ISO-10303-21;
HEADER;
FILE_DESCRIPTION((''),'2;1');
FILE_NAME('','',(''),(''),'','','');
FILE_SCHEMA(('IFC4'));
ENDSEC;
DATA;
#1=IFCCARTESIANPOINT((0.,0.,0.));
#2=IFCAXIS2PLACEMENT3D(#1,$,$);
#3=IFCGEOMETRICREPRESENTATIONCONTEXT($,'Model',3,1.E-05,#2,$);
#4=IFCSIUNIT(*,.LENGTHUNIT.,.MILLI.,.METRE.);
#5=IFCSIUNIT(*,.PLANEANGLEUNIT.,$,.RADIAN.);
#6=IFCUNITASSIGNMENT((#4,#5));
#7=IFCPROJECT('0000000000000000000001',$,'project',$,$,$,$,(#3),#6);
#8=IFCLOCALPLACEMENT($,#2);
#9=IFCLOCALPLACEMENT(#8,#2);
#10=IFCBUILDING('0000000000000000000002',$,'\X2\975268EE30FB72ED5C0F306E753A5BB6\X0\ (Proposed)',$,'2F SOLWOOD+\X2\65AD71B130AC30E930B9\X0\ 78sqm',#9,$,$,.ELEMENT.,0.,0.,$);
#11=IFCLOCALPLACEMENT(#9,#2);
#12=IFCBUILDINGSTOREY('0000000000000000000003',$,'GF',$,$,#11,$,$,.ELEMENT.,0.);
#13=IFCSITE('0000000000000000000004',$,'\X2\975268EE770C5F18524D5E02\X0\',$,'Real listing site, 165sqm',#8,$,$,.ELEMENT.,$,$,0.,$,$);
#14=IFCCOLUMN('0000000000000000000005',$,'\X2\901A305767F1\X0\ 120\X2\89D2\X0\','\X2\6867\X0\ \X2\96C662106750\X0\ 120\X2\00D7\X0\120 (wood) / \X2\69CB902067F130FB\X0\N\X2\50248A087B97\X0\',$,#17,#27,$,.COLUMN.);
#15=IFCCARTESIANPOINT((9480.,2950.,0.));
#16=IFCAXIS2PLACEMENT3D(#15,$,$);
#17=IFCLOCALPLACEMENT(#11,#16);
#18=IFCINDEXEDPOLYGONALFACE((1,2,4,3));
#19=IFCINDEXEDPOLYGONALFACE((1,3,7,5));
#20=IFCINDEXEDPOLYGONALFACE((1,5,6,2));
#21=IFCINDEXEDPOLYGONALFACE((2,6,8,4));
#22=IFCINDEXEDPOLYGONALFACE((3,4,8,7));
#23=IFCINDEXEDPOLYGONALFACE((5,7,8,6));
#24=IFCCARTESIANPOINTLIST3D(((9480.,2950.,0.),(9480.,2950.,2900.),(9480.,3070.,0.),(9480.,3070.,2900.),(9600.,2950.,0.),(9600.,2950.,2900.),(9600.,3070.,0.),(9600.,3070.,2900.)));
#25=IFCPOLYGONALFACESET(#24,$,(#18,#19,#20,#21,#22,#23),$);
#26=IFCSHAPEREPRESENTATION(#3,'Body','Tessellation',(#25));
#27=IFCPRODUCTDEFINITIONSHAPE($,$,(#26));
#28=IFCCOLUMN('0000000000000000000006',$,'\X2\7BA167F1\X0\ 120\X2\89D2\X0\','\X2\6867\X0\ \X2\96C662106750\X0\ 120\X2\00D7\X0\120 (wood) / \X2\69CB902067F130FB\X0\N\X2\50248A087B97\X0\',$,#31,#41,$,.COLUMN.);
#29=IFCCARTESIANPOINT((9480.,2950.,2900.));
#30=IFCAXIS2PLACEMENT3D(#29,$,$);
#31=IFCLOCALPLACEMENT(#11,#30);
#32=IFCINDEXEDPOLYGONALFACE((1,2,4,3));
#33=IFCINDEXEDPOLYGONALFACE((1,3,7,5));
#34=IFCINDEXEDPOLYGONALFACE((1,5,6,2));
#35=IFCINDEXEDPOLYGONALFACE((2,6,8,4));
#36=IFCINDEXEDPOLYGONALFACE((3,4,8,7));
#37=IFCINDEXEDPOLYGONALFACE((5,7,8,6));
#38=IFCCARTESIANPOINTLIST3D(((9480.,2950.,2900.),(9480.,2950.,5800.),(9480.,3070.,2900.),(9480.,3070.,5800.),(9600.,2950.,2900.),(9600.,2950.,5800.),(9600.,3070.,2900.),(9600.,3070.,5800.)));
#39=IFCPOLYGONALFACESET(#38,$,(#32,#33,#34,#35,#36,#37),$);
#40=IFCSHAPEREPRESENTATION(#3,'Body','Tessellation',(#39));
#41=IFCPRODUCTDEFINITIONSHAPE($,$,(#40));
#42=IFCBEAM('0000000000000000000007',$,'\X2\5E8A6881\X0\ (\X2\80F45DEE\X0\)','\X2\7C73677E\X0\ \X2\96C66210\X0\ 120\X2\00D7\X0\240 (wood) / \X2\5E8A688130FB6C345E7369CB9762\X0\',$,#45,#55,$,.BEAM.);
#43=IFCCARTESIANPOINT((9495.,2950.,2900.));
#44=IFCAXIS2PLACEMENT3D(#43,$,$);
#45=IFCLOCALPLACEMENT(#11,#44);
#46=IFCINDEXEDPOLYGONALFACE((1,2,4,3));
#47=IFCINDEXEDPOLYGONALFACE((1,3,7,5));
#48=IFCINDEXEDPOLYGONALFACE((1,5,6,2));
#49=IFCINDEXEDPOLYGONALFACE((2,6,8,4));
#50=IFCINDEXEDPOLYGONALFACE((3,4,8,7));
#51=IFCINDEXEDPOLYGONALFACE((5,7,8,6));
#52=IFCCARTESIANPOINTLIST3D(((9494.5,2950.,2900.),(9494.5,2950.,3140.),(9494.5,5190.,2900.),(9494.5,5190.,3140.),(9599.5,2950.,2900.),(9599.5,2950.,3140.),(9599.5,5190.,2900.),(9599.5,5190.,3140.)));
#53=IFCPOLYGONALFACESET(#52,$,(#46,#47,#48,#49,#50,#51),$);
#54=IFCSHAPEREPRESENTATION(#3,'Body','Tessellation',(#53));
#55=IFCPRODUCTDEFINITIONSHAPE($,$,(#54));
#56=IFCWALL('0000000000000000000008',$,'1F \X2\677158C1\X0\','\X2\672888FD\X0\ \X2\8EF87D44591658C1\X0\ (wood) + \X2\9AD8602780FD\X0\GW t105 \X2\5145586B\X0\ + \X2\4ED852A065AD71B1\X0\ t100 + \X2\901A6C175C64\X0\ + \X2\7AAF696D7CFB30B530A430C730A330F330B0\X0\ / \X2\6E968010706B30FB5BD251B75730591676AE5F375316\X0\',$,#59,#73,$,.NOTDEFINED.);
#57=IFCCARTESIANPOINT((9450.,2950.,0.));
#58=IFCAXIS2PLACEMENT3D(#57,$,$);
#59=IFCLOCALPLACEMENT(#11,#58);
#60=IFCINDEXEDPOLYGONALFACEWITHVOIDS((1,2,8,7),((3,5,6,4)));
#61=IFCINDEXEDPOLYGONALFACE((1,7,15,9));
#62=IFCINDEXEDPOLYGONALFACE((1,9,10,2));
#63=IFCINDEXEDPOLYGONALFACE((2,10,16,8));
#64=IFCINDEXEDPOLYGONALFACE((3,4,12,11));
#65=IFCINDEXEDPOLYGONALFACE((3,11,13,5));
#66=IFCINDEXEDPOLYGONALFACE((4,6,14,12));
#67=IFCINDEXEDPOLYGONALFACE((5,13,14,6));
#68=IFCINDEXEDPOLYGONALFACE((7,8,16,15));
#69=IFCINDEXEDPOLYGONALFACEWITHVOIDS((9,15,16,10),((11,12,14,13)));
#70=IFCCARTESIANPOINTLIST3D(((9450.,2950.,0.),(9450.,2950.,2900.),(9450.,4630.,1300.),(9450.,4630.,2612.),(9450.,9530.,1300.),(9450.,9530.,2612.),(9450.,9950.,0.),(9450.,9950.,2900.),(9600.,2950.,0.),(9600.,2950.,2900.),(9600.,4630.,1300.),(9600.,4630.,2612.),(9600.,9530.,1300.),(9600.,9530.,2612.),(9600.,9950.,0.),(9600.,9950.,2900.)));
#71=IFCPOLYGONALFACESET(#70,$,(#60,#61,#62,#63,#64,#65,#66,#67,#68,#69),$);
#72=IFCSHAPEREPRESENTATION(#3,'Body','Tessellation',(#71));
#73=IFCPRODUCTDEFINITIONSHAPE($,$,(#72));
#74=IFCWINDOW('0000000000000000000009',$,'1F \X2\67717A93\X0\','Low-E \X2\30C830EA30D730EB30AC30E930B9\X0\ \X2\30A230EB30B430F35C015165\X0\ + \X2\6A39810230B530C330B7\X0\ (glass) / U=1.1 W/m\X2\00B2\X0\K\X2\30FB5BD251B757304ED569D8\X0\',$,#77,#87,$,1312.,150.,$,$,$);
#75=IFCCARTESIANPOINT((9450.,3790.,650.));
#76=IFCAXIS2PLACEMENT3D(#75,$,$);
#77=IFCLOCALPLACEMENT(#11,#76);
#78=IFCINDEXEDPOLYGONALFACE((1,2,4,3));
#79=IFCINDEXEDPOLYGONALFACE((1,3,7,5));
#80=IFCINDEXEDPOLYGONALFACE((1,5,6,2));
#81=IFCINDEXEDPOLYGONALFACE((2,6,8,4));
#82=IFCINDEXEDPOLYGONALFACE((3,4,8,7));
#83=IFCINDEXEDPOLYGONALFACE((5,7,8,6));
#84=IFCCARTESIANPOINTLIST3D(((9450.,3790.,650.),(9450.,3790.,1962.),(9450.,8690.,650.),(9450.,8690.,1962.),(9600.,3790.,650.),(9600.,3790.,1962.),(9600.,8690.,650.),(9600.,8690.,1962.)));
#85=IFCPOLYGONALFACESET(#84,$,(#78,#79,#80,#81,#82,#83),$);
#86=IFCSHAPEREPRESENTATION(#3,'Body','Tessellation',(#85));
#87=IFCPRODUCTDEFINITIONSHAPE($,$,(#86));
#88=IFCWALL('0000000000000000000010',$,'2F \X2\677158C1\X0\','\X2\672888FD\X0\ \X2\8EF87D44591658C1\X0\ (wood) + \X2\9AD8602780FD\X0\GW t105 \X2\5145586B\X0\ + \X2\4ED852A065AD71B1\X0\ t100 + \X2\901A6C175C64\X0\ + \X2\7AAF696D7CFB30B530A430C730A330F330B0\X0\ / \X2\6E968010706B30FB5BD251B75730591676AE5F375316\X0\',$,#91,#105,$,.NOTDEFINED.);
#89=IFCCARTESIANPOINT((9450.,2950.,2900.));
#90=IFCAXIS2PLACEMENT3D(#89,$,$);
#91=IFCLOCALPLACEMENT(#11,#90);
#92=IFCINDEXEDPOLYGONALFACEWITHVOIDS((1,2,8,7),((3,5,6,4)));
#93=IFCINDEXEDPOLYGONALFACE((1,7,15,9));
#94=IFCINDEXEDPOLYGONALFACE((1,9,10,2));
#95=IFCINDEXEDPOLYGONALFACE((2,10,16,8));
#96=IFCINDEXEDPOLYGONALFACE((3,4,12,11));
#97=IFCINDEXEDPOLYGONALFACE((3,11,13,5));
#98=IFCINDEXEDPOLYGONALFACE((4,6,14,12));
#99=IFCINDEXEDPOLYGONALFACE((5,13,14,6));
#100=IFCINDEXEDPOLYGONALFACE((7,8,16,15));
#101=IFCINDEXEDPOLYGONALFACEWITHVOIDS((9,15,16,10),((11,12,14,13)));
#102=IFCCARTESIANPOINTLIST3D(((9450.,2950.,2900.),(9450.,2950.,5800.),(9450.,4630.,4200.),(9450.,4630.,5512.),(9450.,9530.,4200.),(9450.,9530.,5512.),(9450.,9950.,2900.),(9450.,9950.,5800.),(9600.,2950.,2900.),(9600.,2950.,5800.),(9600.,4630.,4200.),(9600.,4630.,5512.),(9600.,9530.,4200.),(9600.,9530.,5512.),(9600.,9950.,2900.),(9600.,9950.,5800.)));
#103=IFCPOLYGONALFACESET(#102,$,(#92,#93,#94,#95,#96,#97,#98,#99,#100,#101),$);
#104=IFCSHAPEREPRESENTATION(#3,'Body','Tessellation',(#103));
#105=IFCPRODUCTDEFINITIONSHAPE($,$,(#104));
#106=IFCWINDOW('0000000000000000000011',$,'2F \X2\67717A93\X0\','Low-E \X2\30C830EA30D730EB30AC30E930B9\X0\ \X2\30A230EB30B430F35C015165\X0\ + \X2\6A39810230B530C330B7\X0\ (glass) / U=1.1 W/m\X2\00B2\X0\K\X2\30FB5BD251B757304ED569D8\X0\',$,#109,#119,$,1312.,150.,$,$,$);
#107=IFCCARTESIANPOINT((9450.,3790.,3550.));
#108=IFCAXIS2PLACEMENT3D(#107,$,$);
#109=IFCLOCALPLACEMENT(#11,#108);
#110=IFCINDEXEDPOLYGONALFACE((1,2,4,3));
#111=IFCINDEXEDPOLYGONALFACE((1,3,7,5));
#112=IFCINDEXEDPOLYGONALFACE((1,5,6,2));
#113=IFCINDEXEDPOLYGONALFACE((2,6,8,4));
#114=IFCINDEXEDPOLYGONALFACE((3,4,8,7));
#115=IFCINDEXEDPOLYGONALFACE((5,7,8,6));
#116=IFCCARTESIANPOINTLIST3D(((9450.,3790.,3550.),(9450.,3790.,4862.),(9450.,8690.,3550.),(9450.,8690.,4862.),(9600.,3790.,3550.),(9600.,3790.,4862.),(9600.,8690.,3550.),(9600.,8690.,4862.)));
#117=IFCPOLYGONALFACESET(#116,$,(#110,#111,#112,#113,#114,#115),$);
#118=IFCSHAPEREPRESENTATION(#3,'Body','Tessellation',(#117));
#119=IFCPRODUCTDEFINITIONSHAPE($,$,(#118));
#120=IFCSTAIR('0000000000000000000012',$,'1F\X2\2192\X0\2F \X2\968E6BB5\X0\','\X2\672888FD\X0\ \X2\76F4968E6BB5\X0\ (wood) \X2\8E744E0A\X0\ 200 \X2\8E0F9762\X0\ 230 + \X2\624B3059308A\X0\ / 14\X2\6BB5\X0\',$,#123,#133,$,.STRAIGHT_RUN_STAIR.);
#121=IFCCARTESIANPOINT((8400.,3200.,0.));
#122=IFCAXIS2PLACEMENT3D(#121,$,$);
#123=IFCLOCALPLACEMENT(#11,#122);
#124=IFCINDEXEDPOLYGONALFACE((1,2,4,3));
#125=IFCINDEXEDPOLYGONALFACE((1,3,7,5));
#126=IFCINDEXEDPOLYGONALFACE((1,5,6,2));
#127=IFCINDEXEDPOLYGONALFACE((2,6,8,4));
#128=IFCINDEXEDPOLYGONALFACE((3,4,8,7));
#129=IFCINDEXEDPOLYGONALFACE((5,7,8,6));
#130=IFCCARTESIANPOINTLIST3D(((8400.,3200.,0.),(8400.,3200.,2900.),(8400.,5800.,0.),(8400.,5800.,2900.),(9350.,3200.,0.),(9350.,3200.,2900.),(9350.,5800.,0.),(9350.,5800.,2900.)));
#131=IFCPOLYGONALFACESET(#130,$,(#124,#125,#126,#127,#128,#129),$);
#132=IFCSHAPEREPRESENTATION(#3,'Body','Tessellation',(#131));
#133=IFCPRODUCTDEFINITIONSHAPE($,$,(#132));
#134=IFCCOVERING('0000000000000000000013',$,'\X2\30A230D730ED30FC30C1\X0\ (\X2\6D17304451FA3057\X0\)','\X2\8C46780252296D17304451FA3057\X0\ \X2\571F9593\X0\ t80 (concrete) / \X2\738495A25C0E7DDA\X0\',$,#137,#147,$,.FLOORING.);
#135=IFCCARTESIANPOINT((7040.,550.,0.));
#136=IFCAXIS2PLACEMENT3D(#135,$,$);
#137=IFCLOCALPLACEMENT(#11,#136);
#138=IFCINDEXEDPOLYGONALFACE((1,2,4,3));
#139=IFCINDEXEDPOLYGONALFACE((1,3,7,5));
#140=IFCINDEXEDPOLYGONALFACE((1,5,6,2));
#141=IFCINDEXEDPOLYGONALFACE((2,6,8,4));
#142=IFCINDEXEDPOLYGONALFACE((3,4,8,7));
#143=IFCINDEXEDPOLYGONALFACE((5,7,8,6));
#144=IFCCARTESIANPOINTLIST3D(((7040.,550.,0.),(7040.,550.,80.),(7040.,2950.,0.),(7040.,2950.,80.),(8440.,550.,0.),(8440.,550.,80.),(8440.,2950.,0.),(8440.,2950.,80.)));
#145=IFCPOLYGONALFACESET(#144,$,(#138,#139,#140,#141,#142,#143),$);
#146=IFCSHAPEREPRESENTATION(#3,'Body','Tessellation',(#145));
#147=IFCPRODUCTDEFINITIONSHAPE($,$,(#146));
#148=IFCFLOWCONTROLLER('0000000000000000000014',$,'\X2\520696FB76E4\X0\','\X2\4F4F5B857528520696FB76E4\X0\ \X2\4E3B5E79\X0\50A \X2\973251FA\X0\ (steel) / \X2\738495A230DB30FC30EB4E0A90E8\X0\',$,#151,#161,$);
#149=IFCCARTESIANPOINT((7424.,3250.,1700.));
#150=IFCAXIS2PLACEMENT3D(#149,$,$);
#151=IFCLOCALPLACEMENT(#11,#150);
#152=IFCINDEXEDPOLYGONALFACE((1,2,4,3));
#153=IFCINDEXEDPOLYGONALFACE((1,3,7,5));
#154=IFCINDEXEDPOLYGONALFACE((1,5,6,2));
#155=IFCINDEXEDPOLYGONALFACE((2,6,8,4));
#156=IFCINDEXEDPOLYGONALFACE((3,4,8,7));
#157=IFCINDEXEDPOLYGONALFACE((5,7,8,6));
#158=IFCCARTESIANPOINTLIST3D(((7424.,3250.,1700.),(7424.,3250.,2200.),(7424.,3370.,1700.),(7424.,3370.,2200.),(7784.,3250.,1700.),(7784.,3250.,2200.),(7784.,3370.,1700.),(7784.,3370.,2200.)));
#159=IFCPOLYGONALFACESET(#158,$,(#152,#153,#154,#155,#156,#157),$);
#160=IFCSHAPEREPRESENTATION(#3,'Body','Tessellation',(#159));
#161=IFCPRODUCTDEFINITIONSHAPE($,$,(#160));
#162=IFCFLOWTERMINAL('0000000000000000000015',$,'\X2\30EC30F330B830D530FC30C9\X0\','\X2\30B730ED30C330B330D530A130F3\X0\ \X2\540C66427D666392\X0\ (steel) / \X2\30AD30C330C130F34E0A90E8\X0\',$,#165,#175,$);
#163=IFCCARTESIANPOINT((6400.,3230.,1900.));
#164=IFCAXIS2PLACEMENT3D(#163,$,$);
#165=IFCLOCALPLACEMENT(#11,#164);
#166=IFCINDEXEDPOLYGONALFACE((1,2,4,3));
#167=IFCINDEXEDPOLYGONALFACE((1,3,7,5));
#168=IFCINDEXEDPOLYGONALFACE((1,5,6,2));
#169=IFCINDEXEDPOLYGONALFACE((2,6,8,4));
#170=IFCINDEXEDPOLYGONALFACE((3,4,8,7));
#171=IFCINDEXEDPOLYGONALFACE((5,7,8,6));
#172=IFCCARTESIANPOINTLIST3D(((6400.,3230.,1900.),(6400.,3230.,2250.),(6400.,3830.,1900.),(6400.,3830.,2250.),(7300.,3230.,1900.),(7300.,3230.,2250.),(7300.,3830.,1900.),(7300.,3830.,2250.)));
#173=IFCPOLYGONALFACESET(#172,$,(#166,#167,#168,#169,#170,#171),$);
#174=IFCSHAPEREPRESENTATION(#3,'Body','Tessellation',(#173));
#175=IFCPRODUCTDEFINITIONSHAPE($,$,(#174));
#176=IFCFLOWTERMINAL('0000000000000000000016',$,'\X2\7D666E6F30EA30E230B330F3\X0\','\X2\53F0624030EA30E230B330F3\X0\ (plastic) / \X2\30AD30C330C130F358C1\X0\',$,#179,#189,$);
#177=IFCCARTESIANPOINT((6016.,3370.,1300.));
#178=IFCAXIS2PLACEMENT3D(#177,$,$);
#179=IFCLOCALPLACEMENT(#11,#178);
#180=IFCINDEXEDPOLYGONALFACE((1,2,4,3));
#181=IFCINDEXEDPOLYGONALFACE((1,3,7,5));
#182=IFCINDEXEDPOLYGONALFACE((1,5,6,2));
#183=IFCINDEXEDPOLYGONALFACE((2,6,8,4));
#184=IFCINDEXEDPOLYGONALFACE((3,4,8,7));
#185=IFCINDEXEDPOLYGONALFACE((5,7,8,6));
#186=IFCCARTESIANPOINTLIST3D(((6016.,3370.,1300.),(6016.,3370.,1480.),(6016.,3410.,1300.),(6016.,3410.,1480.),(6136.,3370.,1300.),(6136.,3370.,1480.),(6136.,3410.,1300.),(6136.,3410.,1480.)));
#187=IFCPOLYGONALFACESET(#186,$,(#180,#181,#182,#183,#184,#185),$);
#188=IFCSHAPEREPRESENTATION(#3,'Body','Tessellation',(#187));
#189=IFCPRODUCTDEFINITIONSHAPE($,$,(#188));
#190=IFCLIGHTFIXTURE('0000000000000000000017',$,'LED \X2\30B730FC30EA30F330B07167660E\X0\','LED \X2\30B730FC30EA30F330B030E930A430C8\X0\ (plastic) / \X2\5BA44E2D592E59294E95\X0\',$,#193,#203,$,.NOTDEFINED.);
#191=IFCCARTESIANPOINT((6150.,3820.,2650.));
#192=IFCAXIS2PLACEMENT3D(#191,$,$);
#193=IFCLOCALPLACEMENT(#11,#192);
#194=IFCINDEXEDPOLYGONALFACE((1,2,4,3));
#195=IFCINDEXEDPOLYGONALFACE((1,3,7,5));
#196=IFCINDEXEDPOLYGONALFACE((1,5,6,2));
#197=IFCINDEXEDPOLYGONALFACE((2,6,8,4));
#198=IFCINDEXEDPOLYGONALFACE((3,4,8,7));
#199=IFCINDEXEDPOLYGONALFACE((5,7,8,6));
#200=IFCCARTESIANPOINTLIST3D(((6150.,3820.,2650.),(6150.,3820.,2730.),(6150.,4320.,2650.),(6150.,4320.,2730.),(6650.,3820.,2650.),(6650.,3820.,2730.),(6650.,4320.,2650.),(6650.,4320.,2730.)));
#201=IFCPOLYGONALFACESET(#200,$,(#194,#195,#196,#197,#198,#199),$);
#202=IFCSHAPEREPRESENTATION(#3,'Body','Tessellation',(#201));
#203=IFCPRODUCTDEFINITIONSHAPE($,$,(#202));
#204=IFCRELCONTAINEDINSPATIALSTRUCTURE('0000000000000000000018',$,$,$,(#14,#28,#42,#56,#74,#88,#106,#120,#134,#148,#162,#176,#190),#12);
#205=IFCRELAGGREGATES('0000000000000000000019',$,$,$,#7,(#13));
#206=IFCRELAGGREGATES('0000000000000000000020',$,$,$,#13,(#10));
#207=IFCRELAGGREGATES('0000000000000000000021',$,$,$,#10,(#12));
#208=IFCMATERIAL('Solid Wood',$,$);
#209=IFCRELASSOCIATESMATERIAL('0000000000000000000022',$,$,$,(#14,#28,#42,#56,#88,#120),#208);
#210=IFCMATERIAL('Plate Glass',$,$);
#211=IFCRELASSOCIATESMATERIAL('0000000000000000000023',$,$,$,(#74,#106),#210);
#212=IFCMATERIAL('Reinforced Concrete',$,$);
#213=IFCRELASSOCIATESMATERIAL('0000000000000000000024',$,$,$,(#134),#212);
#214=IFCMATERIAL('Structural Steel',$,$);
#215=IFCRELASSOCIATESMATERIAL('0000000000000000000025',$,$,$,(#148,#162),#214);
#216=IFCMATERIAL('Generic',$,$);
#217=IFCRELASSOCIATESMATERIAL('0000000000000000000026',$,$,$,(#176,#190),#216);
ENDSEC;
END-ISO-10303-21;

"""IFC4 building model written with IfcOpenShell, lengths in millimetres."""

from ifc_helpers import new_model, si_unit, frame, frame_2d, origin, place, context, project, spatial, rectangle, extrude, material, element, fill, save


model = new_model("IFC4")

# Units and contexts
model_context = context("Model", 3, precision=1e-05, world=origin())
ifc_project = project(units=[si_unit("LENGTHUNIT", "METRE", prefix="MILLI"), si_unit("PLANEANGLEUNIT", "RADIAN")], contexts=[model_context])

# Site, building, storey
site_placement = place(None, origin())
site = spatial("IfcSite", under=ifc_project, at=site_placement, Name="青森県弘前市", ObjectType="Real listing site, 165sqm", CompositionType="ELEMENT", RefElevation=0.0)
building_placement = place(site_placement, origin())
building = spatial("IfcBuilding", under=site, at=building_placement, Name="青森・狭小の町家 (Proposed)", ObjectType="2F SOLWOOD+断熱ガラス 78sqm", CompositionType="ELEMENT", ElevationOfRefHeight=0.0, ElevationOfTerrain=0.0)
storey_placement = place(building_placement, origin())
storey = spatial("IfcBuildingStorey", under=building, at=storey_placement, Name="GF", CompositionType="ELEMENT", Elevation=0.0)

# Columns
ifc_material_1 = material(Name="Solid Wood")
column_1_placement = place(storey_placement, frame((9480.0, 2950.0, 0.0)))
element("IfcColumn", 1, at=column_1_placement, inside=storey, material=ifc_material_1, Name="通し柱 120角", Description="桧 集成材 120×120 (wood) / 構造柱・N値計算", PredefinedType="COLUMN", context=model_context, shape_type="SweptSolid", body=[
    extrude(rectangle(XDim=120.0, YDim=120.0, at=frame_2d((60.0, 60.0))), frame((9480.0, 2950.0, 0.0)), (0.0, 0.0, 1.0), 2900.0),
])
column_2_placement = place(storey_placement, frame((9480.0, 2950.0, 2900.0)))
element("IfcColumn", 2, at=column_2_placement, inside=storey, material=ifc_material_1, Name="管柱 120角", Description="桧 集成材 120×120 (wood) / 構造柱・N値計算", PredefinedType="COLUMN", context=model_context, shape_type="SweptSolid", body=[
    extrude(rectangle(XDim=120.0, YDim=120.0, at=frame_2d((60.0, 60.0))), frame((9480.0, 2950.0, 2900.0)), (0.0, 0.0, 1.0), 2900.0),
])

# Beam
beam_1_placement = place(storey_placement, frame((9495.0, 2950.0, 2900.0)))
element("IfcBeam", 3, at=beam_1_placement, inside=storey, material=ifc_material_1, Name="床梁 (胴差)", Description="米松 集成 120×240 (wood) / 床梁・水平構面", PredefinedType="BEAM", context=model_context, shape_type="SweptSolid", body=[
    extrude(rectangle(XDim=105.0, YDim=2240.0, at=frame_2d((52.0, 1120.0))), frame((9495.0, 2950.0, 2900.0)), (0.0, 0.0, 1.0), 240.0),
])

# Wall, opening, window
wall_1_placement = place(storey_placement, frame((9450.0, 2950.0, 0.0)))
wall_1 = element("IfcWall", 4, at=wall_1_placement, inside=storey, material=ifc_material_1, Name="1F 東壁", Description="木製 軸組外壁 (wood) + 高性能GW t105 充填 + 付加断熱 t100 + 通気層 + 窯業系サイディング / 準耐火・寒冷地外皮強化", PredefinedType="NOTDEFINED", context=model_context, shape_type="SweptSolid", body=[
    extrude(rectangle(XDim=150.0, YDim=7000.0, at=frame_2d((75.0, 3500.0))), frame((9450.0, 2950.0, 0.0)), (0.0, 0.0, 1.0), 2900.0),
])
opening_1_placement = place(storey_placement, frame((9450.0, 3790.0, 650.0)))
opening_1 = element("IfcOpeningElement", 5, at=opening_1_placement, cuts=wall_1, PredefinedType="NOTDEFINED", context=model_context, shape_type="SweptSolid", body=[
    extrude(rectangle(XDim=150.0, YDim=4900.0, at=frame_2d((75.0, 2450.0))), frame((9450.0, 3790.0, 650.0)), (0.0, 0.0, 1.0), 1312.0),
])
ifc_material_2 = material(Name="Plate Glass")
window_1_placement = place(storey_placement, frame((9450.0, 3790.0, 650.0)))
window_1 = element("IfcWindow", 6, at=window_1_placement, inside=storey, material=ifc_material_2, Name="1F 東窓", Description="Low-E トリプルガラス アルゴン封入 + 樹脂サッシ (glass) / U=1.1 W/m²K・寒冷地仕様", OverallHeight=1312.0, OverallWidth=150.0, context=model_context, shape_type="SweptSolid", body=[
    extrude(rectangle(XDim=150.0, YDim=4900.0, at=frame_2d((75.0, 2450.0))), frame((9450.0, 3790.0, 650.0)), (0.0, 0.0, 1.0), 1312.0),
])
fill(opening_1, window_1)

# Wall, opening, window
wall_2_placement = place(storey_placement, frame((9450.0, 2950.0, 2900.0)))
wall_2 = element("IfcWall", 7, at=wall_2_placement, inside=storey, material=ifc_material_1, Name="2F 東壁", Description="木製 軸組外壁 (wood) + 高性能GW t105 充填 + 付加断熱 t100 + 通気層 + 窯業系サイディング / 準耐火・寒冷地外皮強化", PredefinedType="NOTDEFINED", context=model_context, shape_type="SweptSolid", body=[
    extrude(rectangle(XDim=150.0, YDim=7000.0, at=frame_2d((75.0, 3500.0))), frame((9450.0, 2950.0, 2900.0)), (0.0, 0.0, 1.0), 2900.0),
])
opening_2_placement = place(storey_placement, frame((9450.0, 3790.0, 3550.0)))
opening_2 = element("IfcOpeningElement", 8, at=opening_2_placement, cuts=wall_2, PredefinedType="NOTDEFINED", context=model_context, shape_type="SweptSolid", body=[
    extrude(rectangle(XDim=150.0, YDim=4900.0, at=frame_2d((75.0, 2450.0))), frame((9450.0, 3790.0, 3550.0)), (0.0, 0.0, 1.0), 1312.0),
])
window_2_placement = place(storey_placement, frame((9450.0, 3790.0, 3550.0)))
window_2 = element("IfcWindow", 9, at=window_2_placement, inside=storey, material=ifc_material_2, Name="2F 東窓", Description="Low-E トリプルガラス アルゴン封入 + 樹脂サッシ (glass) / U=1.1 W/m²K・寒冷地仕様", OverallHeight=1312.0, OverallWidth=150.0, context=model_context, shape_type="SweptSolid", body=[
    extrude(rectangle(XDim=150.0, YDim=4900.0, at=frame_2d((75.0, 2450.0))), frame((9450.0, 3790.0, 3550.0)), (0.0, 0.0, 1.0), 1312.0),
])
fill(opening_2, window_2)

# Stair
stair_placement = place(storey_placement, frame((8400.0, 3200.0, 0.0)))
element("IfcStair", 10, at=stair_placement, inside=storey, material=ifc_material_1, Name="1F→2F 階段", Description="木製 直階段 (wood) 蹴上 200 踏面 230 + 手すり / 14段", PredefinedType="STRAIGHT_RUN_STAIR", context=model_context, shape_type="SweptSolid", body=[
    extrude(rectangle(XDim=950.0, YDim=2600.0, at=frame_2d((475.0, 1300.0))), frame((8400.0, 3200.0, 0.0)), (0.0, 0.0, 1.0), 2900.0),
])

# Covering
ifc_material_3 = material(Name="Reinforced Concrete")
covering_placement = place(storey_placement, frame((7040.0, 550.0, 0.0)))
element("IfcCovering", 11, at=covering_placement, inside=storey, material=ifc_material_3, Name="アプローチ (洗い出し)", Description="豆砂利洗い出し 土間 t80 (concrete) / 玄関導線", PredefinedType="FLOORING", context=model_context, shape_type="SweptSolid", body=[
    extrude(rectangle(XDim=1400.0, YDim=2400.0, at=frame_2d((700.0, 1200.0))), frame((7040.0, 550.0, 0.0)), (0.0, 0.0, 1.0), 80.0),
])

# Flow controller
ifc_material_4 = material(Name="Structural Steel")
flow_controller_placement = place(storey_placement, frame((7424.0, 3250.0, 1700.0)))
element("IfcFlowController", 12, at=flow_controller_placement, inside=storey, material=ifc_material_4, Name="分電盤", Description="住宅用分電盤 主幹50A 露出 (steel) / 玄関ホール上部", context=model_context, shape_type="SweptSolid", body=[
    extrude(rectangle(XDim=360.0, YDim=120.0, at=frame_2d((180.0, 60.0))), frame((7424.0, 3250.0, 1700.0)), (0.0, 0.0, 1.0), 500.0),
])

# Flow terminals
flow_terminal_1_placement = place(storey_placement, frame((6400.0, 3230.0, 1900.0)))
element("IfcFlowTerminal", 13, at=flow_terminal_1_placement, inside=storey, material=ifc_material_4, Name="レンジフード", Description="シロッコファン 同時給排 (steel) / キッチン上部", context=model_context, shape_type="SweptSolid", body=[
    extrude(rectangle(XDim=900.0, YDim=600.0, at=frame_2d((450.0, 300.0))), frame((6400.0, 3230.0, 1900.0)), (0.0, 0.0, 1.0), 350.0),
])
ifc_material_5 = material(Name="Generic")
flow_terminal_2_placement = place(storey_placement, frame((6016.0, 3370.0, 1300.0)))
element("IfcFlowTerminal", 14, at=flow_terminal_2_placement, inside=storey, material=ifc_material_5, Name="給湯リモコン", Description="台所リモコン (plastic) / キッチン壁", context=model_context, shape_type="SweptSolid", body=[
    extrude(rectangle(XDim=120.0, YDim=40.0, at=frame_2d((60.0, 20.0))), frame((6016.0, 3370.0, 1300.0)), (0.0, 0.0, 1.0), 180.0),
])

# Light fixture
light_fixture_1_placement = place(storey_placement, frame((6150.0, 3820.0, 2650.0)))
element("IfcLightFixture", 15, at=light_fixture_1_placement, inside=storey, material=ifc_material_5, Name="LED シーリング照明", Description="LED シーリングライト (plastic) / 室中央天井", PredefinedType="NOTDEFINED", context=model_context, shape_type="SweptSolid", body=[
    extrude(rectangle(XDim=500.0, YDim=500.0, at=frame_2d((250.0, 250.0))), frame((6150.0, 3820.0, 2650.0)), (0.0, 0.0, 1.0), 80.0),
])

save(model, "model.ifc")
